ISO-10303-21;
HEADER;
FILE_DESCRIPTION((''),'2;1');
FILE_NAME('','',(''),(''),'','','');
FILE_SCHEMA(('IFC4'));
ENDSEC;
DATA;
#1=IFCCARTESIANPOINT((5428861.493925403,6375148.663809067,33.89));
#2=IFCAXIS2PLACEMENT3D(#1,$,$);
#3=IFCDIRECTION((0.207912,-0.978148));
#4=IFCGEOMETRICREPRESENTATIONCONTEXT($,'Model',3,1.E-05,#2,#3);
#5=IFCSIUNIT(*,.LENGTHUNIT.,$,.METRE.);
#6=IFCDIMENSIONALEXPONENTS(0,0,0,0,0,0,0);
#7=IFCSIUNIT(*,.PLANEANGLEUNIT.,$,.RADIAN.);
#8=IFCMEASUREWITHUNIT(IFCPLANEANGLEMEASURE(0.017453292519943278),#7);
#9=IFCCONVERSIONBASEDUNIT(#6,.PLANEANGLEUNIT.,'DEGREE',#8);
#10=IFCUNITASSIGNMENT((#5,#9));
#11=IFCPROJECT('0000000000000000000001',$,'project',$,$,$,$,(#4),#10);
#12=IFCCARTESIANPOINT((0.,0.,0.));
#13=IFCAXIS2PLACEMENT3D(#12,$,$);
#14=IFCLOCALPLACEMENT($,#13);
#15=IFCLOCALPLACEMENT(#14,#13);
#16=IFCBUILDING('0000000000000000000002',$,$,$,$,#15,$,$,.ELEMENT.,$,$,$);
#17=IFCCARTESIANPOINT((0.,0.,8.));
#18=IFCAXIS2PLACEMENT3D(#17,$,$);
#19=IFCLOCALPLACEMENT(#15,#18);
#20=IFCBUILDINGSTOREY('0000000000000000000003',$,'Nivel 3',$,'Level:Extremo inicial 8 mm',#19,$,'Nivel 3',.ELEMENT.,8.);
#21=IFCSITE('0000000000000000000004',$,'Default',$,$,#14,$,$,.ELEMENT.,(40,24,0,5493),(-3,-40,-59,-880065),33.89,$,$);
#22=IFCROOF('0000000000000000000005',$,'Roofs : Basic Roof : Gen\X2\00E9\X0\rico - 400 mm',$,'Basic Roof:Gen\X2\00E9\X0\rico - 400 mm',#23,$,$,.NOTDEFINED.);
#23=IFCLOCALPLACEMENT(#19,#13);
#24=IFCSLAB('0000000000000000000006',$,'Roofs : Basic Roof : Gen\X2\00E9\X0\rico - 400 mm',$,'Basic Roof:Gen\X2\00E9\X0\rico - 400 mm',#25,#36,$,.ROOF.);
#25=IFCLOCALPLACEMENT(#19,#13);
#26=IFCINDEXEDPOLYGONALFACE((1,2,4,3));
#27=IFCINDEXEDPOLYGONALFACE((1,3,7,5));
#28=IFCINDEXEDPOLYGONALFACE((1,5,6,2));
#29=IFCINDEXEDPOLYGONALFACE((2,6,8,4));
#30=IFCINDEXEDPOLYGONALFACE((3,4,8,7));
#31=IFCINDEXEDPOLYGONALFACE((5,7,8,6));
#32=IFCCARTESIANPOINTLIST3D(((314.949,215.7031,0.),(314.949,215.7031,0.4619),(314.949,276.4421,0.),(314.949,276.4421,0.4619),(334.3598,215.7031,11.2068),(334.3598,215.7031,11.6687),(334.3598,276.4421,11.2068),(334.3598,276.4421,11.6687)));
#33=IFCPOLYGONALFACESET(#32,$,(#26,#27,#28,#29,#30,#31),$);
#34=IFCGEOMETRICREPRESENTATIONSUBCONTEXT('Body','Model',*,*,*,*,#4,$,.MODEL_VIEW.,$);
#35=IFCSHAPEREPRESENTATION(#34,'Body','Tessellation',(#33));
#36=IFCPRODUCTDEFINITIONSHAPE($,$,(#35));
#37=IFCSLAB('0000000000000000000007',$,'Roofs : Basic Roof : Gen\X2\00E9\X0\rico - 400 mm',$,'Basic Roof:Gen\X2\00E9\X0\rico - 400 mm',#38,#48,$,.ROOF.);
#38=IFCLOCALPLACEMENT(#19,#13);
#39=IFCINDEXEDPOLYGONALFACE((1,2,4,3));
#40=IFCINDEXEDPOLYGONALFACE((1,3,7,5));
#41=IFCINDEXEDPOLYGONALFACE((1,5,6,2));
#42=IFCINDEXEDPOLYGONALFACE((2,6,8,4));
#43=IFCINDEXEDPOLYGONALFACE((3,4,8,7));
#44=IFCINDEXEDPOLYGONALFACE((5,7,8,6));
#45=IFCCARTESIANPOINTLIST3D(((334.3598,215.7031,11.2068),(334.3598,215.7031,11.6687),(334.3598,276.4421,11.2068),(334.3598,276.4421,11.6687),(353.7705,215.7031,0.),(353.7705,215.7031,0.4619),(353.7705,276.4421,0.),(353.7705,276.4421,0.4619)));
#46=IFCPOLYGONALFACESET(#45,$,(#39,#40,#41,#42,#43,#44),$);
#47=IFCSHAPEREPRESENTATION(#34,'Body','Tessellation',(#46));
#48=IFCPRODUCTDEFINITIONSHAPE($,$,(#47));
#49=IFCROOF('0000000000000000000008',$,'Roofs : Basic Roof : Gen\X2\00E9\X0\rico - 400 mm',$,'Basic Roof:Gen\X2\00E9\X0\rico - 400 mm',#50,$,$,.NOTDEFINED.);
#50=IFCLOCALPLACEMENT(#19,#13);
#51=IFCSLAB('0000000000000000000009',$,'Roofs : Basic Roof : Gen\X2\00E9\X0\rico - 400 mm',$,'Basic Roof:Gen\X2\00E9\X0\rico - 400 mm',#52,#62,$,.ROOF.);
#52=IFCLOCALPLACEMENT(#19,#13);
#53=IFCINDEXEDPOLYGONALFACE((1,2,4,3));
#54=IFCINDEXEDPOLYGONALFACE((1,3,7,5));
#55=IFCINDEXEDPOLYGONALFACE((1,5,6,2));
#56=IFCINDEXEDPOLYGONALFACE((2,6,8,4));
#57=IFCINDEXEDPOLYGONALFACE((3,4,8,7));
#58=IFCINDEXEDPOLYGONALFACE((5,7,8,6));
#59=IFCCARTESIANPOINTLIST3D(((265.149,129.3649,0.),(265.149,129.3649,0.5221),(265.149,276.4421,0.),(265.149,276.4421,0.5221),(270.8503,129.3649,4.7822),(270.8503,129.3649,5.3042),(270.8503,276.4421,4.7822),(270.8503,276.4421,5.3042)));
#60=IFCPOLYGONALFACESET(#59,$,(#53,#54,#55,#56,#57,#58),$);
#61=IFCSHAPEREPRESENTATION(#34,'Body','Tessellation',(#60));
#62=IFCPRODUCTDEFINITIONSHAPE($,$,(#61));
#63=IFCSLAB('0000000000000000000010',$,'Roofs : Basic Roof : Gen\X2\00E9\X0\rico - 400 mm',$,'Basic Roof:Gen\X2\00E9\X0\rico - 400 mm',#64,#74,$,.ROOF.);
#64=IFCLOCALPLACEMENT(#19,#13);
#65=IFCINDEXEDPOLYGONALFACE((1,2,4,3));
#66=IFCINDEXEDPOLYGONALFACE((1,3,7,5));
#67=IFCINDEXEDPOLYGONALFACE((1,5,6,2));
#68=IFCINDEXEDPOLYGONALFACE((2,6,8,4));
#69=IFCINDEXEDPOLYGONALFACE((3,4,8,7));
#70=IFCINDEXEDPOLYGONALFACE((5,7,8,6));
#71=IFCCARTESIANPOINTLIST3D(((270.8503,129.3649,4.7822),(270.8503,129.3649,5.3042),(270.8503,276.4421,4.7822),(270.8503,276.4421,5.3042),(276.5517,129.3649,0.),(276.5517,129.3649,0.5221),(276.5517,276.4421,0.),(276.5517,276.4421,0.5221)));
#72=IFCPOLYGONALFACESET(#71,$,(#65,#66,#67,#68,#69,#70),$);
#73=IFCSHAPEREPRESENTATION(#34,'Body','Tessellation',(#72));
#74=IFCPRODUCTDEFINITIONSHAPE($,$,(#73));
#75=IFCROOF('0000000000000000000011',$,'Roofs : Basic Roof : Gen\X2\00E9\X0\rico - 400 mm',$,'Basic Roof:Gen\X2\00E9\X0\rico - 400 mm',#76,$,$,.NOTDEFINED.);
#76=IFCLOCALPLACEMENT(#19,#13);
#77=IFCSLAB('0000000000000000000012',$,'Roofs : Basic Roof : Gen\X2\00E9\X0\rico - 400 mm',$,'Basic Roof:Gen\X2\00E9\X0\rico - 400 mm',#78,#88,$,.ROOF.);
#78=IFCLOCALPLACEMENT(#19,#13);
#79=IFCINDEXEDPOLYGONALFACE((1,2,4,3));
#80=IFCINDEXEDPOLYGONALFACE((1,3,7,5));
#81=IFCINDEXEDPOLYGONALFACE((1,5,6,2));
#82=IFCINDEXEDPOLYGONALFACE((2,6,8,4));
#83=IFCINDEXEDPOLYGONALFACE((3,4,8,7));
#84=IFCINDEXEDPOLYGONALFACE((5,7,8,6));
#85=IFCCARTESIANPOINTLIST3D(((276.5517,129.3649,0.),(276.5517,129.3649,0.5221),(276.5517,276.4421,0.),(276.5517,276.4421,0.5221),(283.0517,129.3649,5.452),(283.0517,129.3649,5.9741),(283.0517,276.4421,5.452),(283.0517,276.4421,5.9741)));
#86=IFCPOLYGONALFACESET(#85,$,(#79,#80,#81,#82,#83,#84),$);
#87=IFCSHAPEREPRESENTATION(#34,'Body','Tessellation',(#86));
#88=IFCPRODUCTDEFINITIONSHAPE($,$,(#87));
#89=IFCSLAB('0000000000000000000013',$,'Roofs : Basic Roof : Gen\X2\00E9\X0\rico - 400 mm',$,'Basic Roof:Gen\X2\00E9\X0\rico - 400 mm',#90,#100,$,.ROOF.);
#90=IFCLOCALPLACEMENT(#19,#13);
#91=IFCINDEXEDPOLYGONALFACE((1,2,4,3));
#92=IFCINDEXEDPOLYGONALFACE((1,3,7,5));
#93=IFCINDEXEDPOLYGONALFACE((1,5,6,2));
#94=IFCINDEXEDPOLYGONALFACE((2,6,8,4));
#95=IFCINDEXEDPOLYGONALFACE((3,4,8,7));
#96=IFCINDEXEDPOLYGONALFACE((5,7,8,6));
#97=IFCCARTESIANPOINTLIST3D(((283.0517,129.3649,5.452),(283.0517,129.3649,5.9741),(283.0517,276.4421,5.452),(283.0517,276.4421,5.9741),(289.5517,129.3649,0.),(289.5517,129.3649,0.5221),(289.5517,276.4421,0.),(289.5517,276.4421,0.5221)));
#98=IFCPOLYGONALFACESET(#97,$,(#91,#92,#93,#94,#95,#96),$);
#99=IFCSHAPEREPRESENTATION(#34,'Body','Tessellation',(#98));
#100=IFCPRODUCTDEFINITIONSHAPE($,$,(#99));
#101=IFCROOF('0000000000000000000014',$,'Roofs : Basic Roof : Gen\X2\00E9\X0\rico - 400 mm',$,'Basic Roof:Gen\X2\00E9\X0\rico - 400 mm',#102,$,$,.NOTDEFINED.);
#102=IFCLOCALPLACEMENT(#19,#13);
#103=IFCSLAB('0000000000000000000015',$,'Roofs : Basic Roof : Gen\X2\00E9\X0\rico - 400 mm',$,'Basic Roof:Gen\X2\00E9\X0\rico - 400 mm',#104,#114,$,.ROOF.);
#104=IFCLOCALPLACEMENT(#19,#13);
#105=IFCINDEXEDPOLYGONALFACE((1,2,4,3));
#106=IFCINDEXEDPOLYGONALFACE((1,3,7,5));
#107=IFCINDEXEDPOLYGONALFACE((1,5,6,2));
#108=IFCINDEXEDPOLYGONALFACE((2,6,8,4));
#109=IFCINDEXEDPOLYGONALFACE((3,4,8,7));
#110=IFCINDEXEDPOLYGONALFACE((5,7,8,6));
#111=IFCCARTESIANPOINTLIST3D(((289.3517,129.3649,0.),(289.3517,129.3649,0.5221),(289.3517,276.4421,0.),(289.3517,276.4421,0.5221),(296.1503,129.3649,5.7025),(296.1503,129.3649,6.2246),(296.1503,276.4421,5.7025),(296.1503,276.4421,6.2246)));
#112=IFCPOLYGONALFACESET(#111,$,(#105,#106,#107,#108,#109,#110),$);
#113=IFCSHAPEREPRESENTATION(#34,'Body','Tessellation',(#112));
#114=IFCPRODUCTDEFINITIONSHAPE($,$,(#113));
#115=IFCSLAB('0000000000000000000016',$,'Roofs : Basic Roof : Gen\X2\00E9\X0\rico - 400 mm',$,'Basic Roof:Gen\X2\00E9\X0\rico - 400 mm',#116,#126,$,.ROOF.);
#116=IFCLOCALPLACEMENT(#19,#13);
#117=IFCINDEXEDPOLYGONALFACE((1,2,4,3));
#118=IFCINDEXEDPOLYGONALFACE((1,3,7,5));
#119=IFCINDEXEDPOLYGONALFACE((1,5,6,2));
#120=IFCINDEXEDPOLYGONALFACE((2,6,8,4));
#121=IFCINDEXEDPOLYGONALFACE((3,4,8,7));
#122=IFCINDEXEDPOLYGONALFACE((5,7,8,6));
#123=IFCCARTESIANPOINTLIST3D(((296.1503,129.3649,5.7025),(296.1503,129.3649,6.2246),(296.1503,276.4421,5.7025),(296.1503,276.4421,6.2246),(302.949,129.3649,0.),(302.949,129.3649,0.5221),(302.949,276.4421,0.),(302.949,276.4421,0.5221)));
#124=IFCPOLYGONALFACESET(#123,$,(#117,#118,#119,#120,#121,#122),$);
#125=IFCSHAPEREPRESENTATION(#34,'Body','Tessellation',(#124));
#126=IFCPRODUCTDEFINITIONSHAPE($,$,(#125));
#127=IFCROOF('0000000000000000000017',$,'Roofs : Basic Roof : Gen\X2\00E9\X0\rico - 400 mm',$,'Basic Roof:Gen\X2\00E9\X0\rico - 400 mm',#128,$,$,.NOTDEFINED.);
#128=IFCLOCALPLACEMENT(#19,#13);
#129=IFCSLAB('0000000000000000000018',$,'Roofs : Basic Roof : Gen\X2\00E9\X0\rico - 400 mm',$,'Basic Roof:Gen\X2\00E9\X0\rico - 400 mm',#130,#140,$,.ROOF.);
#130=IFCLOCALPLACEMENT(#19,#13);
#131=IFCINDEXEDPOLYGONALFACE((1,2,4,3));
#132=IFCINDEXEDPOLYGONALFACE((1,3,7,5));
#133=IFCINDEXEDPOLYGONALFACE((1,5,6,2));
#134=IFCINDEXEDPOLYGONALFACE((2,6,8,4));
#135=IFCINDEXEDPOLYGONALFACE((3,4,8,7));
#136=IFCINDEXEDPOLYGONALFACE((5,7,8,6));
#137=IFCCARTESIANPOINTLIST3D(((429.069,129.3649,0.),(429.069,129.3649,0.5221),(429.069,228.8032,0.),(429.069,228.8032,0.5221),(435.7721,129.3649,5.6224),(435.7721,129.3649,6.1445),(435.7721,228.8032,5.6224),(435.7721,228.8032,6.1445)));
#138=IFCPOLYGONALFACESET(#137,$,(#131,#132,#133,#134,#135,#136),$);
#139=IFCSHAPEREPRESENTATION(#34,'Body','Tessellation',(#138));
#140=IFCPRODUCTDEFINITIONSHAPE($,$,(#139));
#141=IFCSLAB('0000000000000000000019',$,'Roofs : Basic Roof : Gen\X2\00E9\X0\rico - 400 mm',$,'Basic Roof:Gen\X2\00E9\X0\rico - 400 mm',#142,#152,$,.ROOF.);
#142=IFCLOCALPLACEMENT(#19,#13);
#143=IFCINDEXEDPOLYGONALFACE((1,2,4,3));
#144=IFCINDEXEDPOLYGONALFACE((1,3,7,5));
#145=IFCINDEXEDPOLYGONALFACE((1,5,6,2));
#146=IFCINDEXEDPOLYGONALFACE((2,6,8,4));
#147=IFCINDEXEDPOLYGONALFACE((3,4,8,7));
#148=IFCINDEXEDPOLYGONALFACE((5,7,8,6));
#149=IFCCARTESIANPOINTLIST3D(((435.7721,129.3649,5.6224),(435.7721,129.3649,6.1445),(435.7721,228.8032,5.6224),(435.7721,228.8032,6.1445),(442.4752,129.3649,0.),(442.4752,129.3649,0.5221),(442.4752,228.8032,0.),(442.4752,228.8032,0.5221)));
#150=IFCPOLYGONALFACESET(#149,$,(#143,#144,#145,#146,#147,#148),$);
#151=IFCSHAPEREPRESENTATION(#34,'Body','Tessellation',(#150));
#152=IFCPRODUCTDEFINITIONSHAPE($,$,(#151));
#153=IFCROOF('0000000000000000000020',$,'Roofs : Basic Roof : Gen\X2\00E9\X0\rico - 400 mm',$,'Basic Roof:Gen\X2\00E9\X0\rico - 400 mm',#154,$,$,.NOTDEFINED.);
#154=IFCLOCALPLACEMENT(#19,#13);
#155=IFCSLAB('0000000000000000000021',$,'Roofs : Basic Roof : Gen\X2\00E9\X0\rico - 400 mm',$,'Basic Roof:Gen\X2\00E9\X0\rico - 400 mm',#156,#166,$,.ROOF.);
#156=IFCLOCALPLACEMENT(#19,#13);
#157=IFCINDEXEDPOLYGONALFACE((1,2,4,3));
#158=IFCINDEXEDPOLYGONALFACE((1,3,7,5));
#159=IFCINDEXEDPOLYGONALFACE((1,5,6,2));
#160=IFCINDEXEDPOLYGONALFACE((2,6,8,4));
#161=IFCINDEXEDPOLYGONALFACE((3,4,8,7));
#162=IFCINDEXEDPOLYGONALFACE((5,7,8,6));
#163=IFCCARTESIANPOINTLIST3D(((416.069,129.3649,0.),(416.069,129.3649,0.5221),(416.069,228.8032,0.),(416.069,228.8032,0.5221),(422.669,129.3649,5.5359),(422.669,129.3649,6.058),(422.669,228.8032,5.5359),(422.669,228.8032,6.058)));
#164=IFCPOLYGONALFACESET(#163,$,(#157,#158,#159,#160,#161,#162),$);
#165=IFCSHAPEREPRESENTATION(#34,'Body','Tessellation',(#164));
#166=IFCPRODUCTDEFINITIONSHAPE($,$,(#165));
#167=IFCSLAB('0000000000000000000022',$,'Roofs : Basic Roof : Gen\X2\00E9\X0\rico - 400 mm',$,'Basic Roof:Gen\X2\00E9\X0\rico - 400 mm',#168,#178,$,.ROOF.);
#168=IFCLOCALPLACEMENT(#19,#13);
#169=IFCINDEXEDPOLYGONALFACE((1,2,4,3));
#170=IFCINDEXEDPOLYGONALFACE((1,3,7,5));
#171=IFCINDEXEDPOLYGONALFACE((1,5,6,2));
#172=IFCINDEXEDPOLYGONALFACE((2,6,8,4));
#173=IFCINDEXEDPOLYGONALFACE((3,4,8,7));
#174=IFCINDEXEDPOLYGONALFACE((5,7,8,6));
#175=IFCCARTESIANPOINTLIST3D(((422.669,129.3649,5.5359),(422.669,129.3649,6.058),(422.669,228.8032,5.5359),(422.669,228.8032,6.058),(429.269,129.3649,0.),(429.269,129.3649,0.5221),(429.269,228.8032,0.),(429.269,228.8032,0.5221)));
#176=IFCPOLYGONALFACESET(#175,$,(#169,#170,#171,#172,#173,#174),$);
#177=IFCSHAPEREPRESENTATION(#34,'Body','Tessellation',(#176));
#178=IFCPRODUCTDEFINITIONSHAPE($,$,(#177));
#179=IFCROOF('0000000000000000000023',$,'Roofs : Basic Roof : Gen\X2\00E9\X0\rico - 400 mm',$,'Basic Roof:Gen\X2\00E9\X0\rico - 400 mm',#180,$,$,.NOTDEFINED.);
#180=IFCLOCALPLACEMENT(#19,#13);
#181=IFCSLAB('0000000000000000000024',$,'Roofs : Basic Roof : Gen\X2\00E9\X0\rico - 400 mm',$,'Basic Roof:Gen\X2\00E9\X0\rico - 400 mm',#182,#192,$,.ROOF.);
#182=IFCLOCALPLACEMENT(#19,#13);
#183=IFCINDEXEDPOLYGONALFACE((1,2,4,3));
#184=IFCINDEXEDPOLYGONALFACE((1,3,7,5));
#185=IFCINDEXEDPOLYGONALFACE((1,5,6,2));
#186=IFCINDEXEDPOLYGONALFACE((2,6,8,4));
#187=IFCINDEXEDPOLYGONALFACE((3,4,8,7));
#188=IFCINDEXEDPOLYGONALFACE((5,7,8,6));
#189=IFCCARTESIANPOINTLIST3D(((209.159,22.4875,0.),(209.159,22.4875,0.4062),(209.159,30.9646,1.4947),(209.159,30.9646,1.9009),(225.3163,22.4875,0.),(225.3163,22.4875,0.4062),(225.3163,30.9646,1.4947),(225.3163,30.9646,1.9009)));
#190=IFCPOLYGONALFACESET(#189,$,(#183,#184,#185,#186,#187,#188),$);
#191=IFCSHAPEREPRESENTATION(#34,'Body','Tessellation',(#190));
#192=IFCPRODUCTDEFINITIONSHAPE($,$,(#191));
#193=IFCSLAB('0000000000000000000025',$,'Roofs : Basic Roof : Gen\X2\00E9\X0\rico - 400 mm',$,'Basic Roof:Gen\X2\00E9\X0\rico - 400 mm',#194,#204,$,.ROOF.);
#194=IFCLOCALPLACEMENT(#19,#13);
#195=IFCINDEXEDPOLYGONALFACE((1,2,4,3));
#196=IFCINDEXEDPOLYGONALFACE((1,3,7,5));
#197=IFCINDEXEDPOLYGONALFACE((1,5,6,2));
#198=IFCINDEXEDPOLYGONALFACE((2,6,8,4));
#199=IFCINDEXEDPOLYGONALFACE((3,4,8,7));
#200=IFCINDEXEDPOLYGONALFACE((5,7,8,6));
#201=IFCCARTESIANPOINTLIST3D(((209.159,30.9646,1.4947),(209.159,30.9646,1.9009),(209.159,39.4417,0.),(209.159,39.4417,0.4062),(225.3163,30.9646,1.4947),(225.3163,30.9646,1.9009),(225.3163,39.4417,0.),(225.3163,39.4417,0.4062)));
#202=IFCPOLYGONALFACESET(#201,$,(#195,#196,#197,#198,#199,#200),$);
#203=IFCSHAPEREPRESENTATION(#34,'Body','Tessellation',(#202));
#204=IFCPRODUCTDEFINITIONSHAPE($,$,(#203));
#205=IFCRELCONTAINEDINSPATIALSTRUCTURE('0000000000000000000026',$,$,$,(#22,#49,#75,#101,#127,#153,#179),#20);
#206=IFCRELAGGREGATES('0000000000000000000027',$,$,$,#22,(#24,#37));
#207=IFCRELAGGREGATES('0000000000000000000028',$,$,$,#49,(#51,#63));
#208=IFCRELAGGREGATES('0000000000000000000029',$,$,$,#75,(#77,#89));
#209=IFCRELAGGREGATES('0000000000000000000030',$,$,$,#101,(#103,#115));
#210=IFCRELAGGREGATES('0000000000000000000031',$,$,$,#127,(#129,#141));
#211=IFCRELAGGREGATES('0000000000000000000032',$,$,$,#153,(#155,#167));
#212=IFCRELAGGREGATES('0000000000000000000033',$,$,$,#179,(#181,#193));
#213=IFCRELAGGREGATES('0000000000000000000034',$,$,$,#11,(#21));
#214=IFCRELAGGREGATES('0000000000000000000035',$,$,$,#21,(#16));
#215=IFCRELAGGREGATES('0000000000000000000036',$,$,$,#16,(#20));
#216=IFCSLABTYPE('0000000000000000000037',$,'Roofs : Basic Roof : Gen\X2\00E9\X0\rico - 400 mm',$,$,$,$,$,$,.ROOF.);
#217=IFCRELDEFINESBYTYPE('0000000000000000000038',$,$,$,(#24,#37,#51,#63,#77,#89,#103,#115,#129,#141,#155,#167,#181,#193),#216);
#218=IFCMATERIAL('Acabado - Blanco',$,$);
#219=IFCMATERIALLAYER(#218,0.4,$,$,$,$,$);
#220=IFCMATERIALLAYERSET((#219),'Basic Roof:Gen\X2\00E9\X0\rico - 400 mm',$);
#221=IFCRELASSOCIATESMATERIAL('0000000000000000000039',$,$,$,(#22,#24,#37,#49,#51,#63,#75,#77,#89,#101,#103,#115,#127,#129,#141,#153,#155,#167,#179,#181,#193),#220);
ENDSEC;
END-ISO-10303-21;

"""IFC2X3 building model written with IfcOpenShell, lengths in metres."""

from ifc_helpers import new_model, entity, si_unit, converted_unit, direction, frame, frame_2d, origin, origin_2d_with_axis, place, context, subcontext, project, spatial, rectangle, extrude, material, layer, layer_set, type_object, element, aggregate, save


model = new_model("IFC2X3")

# Units and contexts
model_context = context("Model", 3, precision=1e-05, world=frame((5428861.493925403, 6375148.663809067, 33.89)), true_north=direction((0.207912, -0.978148)))
body_context = subcontext(model_context, "Body", "Model", "MODEL_VIEW")
ifc_project = project(units=[si_unit("LENGTHUNIT", "METRE"), converted_unit("PLANEANGLEUNIT", "DEGREE", entity("IfcPlaneAngleMeasure", 0.017453292519943278), si_unit("PLANEANGLEUNIT", "RADIAN"), dimensions=[0, 0, 0, 0, 0, 0, 0])], contexts=[model_context])

# Site, building, storey
site_placement = place(None, origin())
site = spatial("IfcSite", under=ifc_project, at=site_placement, Name="Default", CompositionType="ELEMENT", RefLatitude=(40, 24, 0, 5493), RefLongitude=(-3, -40, -59, -880065), RefElevation=33.89)
building_placement = place(site_placement, origin())
building = spatial("IfcBuilding", under=site, at=building_placement, CompositionType="ELEMENT")
storey_placement = place(building_placement, frame((0.0, 0.0, 8.0)))
storey = spatial("IfcBuildingStorey", under=building, at=storey_placement, Name="Nivel 3", ObjectType="Level:Extremo inicial 8 mm", LongName="Nivel 3", CompositionType="ELEMENT", Elevation=8.0)

# Roofs, slabs
ifc_material = material(Name="Acabado - Blanco")
ifc_layer = layer(ifc_material, 0.4)
ifc_layer_set = layer_set([ifc_layer], Name="Basic Roof:Genérico - 400 mm")
roof_1_placement = place(storey_placement, frame((314.949, 215.7031, 0.0)))
roof_1 = element("IfcRoof", 1, at=roof_1_placement, inside=storey, material=ifc_layer_set, Name="Roofs : Basic Roof : Genérico - 400 mm", ObjectType="Basic Roof:Genérico - 400 mm", ShapeType="NOTDEFINED")
slab_type = type_object("IfcSlabType", Name="Roofs : Basic Roof : Genérico - 400 mm", PredefinedType="ROOF")
slab_1_placement = place(roof_1_placement, origin())
slab_1 = element("IfcSlab", 2, at=slab_1_placement, type_object=slab_type, material=ifc_layer_set, Name="Roofs : Basic Roof : Genérico - 400 mm", ObjectType="Basic Roof:Genérico - 400 mm", PredefinedType="ROOF", context=body_context, shape_type="SweptSolid", body=[
    extrude(rectangle(XDim=60.7389, YDim=22.4136, at=frame_2d((0.0, 0.0), x_axis=(0.0, 1.0))), frame((9.7054, 30.3695, 5.6034), z_axis=(-0.5, 0.0, 0.866025), x_axis=(0.866025, 0.0, 0.5)), (0.5, 0.0, 0.866025), 0.4619),
])
slab_2_placement = place(roof_1_placement, origin())
slab_2 = element("IfcSlab", 3, at=slab_2_placement, type_object=slab_type, material=ifc_layer_set, Name="Roofs : Basic Roof : Genérico - 400 mm", ObjectType="Basic Roof:Genérico - 400 mm", PredefinedType="ROOF", context=body_context, shape_type="SweptSolid", body=[
    extrude(rectangle(XDim=22.4136, YDim=60.7389, at=frame_2d((0.0, 0.0), x_axis=(1.0, 0.0))), frame((29.1162, 30.3695, 5.6034), z_axis=(0.5, 0.0, 0.866025), x_axis=(0.866025, 0.0, -0.5)), (-0.5, 0.0, 0.866025), 0.4619),
])
aggregate(roof_1, [slab_1, slab_2])
roof_2_placement = place(storey_placement, frame((265.149, 129.3649, 0.0)))
roof_2 = element("IfcRoof", 4, at=roof_2_placement, inside=storey, material=ifc_layer_set, Name="Roofs : Basic Roof : Genérico - 400 mm", ObjectType="Basic Roof:Genérico - 400 mm", ShapeType="NOTDEFINED")
slab_3_placement = place(roof_2_placement, origin())
slab_3 = element("IfcSlab", 5, at=slab_3_placement, type_object=slab_type, material=ifc_layer_set, Name="Roofs : Basic Roof : Genérico - 400 mm", ObjectType="Basic Roof:Genérico - 400 mm", PredefinedType="ROOF", context=body_context, shape_type="SweptSolid", body=[
    extrude(rectangle(XDim=147.0772, YDim=7.4414, at=frame_2d((0.0, 0.0), x_axis=(0.0, 1.0))), frame((2.8507, 73.5386, 2.3911), z_axis=(-0.642641, 0.0, 0.766167), x_axis=(0.766167, 0.0, 0.642641)), (0.642641, 0.0, 0.766167), 0.5221),
])
slab_4_placement = place(roof_2_placement, origin())
slab_4 = element("IfcSlab", 6, at=slab_4_placement, type_object=slab_type, material=ifc_layer_set, Name="Roofs : Basic Roof : Genérico - 400 mm", ObjectType="Basic Roof:Genérico - 400 mm", PredefinedType="ROOF", context=body_context, shape_type="SweptSolid", body=[
    extrude(rectangle(XDim=7.4414, YDim=147.0772, at=frame_2d((0.0, 0.0), x_axis=(1.0, 0.0))), frame((8.552, 73.5386, 2.3911), z_axis=(0.642641, 0.0, 0.766167), x_axis=(0.766167, 0.0, -0.642641)), (-0.642641, 0.0, 0.766167), 0.5221),
])
aggregate(roof_2, [slab_3, slab_4])
roof_3_placement = place(storey_placement, frame((276.5517, 129.3649, 0.0)))
roof_3 = element("IfcRoof", 7, at=roof_3_placement, inside=storey, material=ifc_layer_set, Name="Roofs : Basic Roof : Genérico - 400 mm", ObjectType="Basic Roof:Genérico - 400 mm", ShapeType="NOTDEFINED")
slab_5_placement = place(roof_3_placement, origin())
slab_5 = element("IfcSlab", 8, at=slab_5_placement, type_object=slab_type, material=ifc_layer_set, Name="Roofs : Basic Roof : Genérico - 400 mm", ObjectType="Basic Roof:Genérico - 400 mm", PredefinedType="ROOF", context=body_context, shape_type="SweptSolid", body=[
    extrude(rectangle(XDim=147.0772, YDim=8.4838, at=frame_2d((0.0, 0.0), x_axis=(0.0, 1.0))), frame((3.25, 73.5386, 2.726), z_axis=(-0.642641, 0.0, 0.766167), x_axis=(0.766167, 0.0, 0.642641)), (0.642641, 0.0, 0.766167), 0.5221),
])
slab_6_placement = place(roof_3_placement, origin())
slab_6 = element("IfcSlab", 9, at=slab_6_placement, type_object=slab_type, material=ifc_layer_set, Name="Roofs : Basic Roof : Genérico - 400 mm", ObjectType="Basic Roof:Genérico - 400 mm", PredefinedType="ROOF", context=body_context, shape_type="SweptSolid", body=[
    extrude(rectangle(XDim=8.4838, YDim=147.0772, at=frame_2d((0.0, 0.0), x_axis=(1.0, 0.0))), frame((9.75, 73.5386, 2.726), z_axis=(0.642641, 0.0, 0.766167), x_axis=(0.766167, 0.0, -0.642641)), (-0.642641, 0.0, 0.766167), 0.5221),
])
aggregate(roof_3, [slab_5, slab_6])
roof_4_placement = place(storey_placement, frame((289.3517, 129.3649, 0.0)))
roof_4 = element("IfcRoof", 10, at=roof_4_placement, inside=storey, material=ifc_layer_set, Name="Roofs : Basic Roof : Genérico - 400 mm", ObjectType="Basic Roof:Genérico - 400 mm", ShapeType="NOTDEFINED")
slab_7_placement = place(roof_4_placement, origin())
slab_7 = element("IfcSlab", 11, at=slab_7_placement, type_object=slab_type, material=ifc_layer_set, Name="Roofs : Basic Roof : Genérico - 400 mm", ObjectType="Basic Roof:Genérico - 400 mm", PredefinedType="ROOF", context=body_context, shape_type="SweptSolid", body=[
    extrude(rectangle(XDim=147.0772, YDim=8.8736, at=frame_2d((0.0, 0.0), x_axis=(0.0, 1.0))), frame((3.3993, 73.5386, 2.8513), z_axis=(-0.642641, 0.0, 0.766167), x_axis=(0.766167, 0.0, 0.642641)), (0.642641, 0.0, 0.766167), 0.5221),
])
slab_8_placement = place(roof_4_placement, origin())
slab_8 = element("IfcSlab", 12, at=slab_8_placement, type_object=slab_type, material=ifc_layer_set, Name="Roofs : Basic Roof : Genérico - 400 mm", ObjectType="Basic Roof:Genérico - 400 mm", PredefinedType="ROOF", context=body_context, shape_type="SweptSolid", body=[
    extrude(rectangle(XDim=8.8736, YDim=147.0772, at=frame_2d((0.0, 0.0), x_axis=(1.0, 0.0))), frame((10.198, 73.5386, 2.8513), z_axis=(0.642641, 0.0, 0.766167), x_axis=(0.766167, 0.0, -0.642641)), (-0.642641, 0.0, 0.766167), 0.5221),
])
aggregate(roof_4, [slab_7, slab_8])
roof_5_placement = place(storey_placement, frame((429.069, 129.3649, 0.0)))
roof_5 = element("IfcRoof", 13, at=roof_5_placement, inside=storey, material=ifc_layer_set, Name="Roofs : Basic Roof : Genérico - 400 mm", ObjectType="Basic Roof:Genérico - 400 mm", ShapeType="NOTDEFINED")
slab_9_placement = place(roof_5_placement, origin())
slab_9 = element("IfcSlab", 14, at=slab_9_placement, type_object=slab_type, material=ifc_layer_set, Name="Roofs : Basic Roof : Genérico - 400 mm", ObjectType="Basic Roof:Genérico - 400 mm", PredefinedType="ROOF", context=body_context, shape_type="SweptSolid", body=[
    extrude(rectangle(XDim=99.4383, YDim=8.7489, at=frame_2d((0.0, 0.0), x_axis=(0.0, 1.0))), frame((3.3515, 49.7191, 2.8112), z_axis=(-0.642641, 0.0, 0.766167), x_axis=(0.766167, 0.0, 0.642641)), (0.642641, 0.0, 0.766167), 0.5221),
])
slab_10_placement = place(roof_5_placement, origin())
slab_10 = element("IfcSlab", 15, at=slab_10_placement, type_object=slab_type, material=ifc_layer_set, Name="Roofs : Basic Roof : Genérico - 400 mm", ObjectType="Basic Roof:Genérico - 400 mm", PredefinedType="ROOF", context=body_context, shape_type="SweptSolid", body=[
    extrude(rectangle(XDim=8.7489, YDim=99.4383, at=frame_2d((0.0, 0.0), x_axis=(1.0, 0.0))), frame((10.0546, 49.7191, 2.8112), z_axis=(0.642641, 0.0, 0.766167), x_axis=(0.766167, 0.0, -0.642641)), (-0.642641, 0.0, 0.766167), 0.5221),
])
aggregate(roof_5, [slab_9, slab_10])
roof_6_placement = place(storey_placement, frame((416.069, 129.3649, 0.0)))
roof_6 = element("IfcRoof", 16, at=roof_6_placement, inside=storey, material=ifc_layer_set, Name="Roofs : Basic Roof : Genérico - 400 mm", ObjectType="Basic Roof:Genérico - 400 mm", ShapeType="NOTDEFINED")
slab_11_placement = place(roof_6_placement, origin())
slab_11 = element("IfcSlab", 17, at=slab_11_placement, type_object=slab_type, material=ifc_layer_set, Name="Roofs : Basic Roof : Genérico - 400 mm", ObjectType="Basic Roof:Genérico - 400 mm", PredefinedType="ROOF", context=body_context, shape_type="SweptSolid", body=[
    extrude(rectangle(XDim=99.4383, YDim=8.6143, at=frame_2d((0.0, 0.0), x_axis=(0.0, 1.0))), frame((3.3, 49.7191, 2.768), z_axis=(-0.642641, 0.0, 0.766167), x_axis=(0.766167, 0.0, 0.642641)), (0.642641, 0.0, 0.766167), 0.5221),
])
slab_12_placement = place(roof_6_placement, origin())
slab_12 = element("IfcSlab", 18, at=slab_12_placement, type_object=slab_type, material=ifc_layer_set, Name="Roofs : Basic Roof : Genérico - 400 mm", ObjectType="Basic Roof:Genérico - 400 mm", PredefinedType="ROOF", context=body_context, shape_type="SweptSolid", body=[
    extrude(rectangle(XDim=8.6143, YDim=99.4383, at=frame_2d((0.0, 0.0), x_axis=(1.0, 0.0))), frame((9.9, 49.7191, 2.768), z_axis=(0.642641, 0.0, 0.766167), x_axis=(0.766167, 0.0, -0.642641)), (-0.642641, 0.0, 0.766167), 0.5221),
])
aggregate(roof_6, [slab_11, slab_12])
roof_7_placement = place(storey_placement, frame((209.159, 22.4875, 0.0)))
roof_7 = element("IfcRoof", 19, at=roof_7_placement, inside=storey, material=ifc_layer_set, Name="Roofs : Basic Roof : Genérico - 400 mm", ObjectType="Basic Roof:Genérico - 400 mm", ShapeType="NOTDEFINED")
slab_13_placement = place(roof_7_placement, origin())
slab_13 = element("IfcSlab", 20, at=slab_13_placement, type_object=slab_type, material=ifc_layer_set, Name="Roofs : Basic Roof : Genérico - 400 mm", ObjectType="Basic Roof:Genérico - 400 mm", PredefinedType="ROOF", context=body_context, shape_type="SweptSolid", body=[
    extrude(rectangle(XDim=8.6079, YDim=16.1573, at=frame_2d((0.0, 0.0), x_axis=(0.0, 1.0))), frame((8.0787, 4.2386, 0.7474), z_axis=(0.0, -0.173648, 0.984808), x_axis=(1.0, 0.0, 0.0)), (0.0, 0.173648, 0.984808), 0.4062),
])
slab_14_placement = place(roof_7_placement, origin())
slab_14 = element("IfcSlab", 21, at=slab_14_placement, type_object=slab_type, material=ifc_layer_set, Name="Roofs : Basic Roof : Genérico - 400 mm", ObjectType="Basic Roof:Genérico - 400 mm", PredefinedType="ROOF", context=body_context, shape_type="SweptSolid", body=[
    extrude(rectangle(XDim=16.1573, YDim=8.6079, at=origin_2d_with_axis()), frame((8.0787, 12.7157, 0.7474), z_axis=(0.0, 0.173648, 0.984808), x_axis=(1.0, 0.0, 0.0)), (0.0, -0.173648, 0.984808), 0.4062),
])
aggregate(roof_7, [slab_13, slab_14])

save(model, "model.ifc")
